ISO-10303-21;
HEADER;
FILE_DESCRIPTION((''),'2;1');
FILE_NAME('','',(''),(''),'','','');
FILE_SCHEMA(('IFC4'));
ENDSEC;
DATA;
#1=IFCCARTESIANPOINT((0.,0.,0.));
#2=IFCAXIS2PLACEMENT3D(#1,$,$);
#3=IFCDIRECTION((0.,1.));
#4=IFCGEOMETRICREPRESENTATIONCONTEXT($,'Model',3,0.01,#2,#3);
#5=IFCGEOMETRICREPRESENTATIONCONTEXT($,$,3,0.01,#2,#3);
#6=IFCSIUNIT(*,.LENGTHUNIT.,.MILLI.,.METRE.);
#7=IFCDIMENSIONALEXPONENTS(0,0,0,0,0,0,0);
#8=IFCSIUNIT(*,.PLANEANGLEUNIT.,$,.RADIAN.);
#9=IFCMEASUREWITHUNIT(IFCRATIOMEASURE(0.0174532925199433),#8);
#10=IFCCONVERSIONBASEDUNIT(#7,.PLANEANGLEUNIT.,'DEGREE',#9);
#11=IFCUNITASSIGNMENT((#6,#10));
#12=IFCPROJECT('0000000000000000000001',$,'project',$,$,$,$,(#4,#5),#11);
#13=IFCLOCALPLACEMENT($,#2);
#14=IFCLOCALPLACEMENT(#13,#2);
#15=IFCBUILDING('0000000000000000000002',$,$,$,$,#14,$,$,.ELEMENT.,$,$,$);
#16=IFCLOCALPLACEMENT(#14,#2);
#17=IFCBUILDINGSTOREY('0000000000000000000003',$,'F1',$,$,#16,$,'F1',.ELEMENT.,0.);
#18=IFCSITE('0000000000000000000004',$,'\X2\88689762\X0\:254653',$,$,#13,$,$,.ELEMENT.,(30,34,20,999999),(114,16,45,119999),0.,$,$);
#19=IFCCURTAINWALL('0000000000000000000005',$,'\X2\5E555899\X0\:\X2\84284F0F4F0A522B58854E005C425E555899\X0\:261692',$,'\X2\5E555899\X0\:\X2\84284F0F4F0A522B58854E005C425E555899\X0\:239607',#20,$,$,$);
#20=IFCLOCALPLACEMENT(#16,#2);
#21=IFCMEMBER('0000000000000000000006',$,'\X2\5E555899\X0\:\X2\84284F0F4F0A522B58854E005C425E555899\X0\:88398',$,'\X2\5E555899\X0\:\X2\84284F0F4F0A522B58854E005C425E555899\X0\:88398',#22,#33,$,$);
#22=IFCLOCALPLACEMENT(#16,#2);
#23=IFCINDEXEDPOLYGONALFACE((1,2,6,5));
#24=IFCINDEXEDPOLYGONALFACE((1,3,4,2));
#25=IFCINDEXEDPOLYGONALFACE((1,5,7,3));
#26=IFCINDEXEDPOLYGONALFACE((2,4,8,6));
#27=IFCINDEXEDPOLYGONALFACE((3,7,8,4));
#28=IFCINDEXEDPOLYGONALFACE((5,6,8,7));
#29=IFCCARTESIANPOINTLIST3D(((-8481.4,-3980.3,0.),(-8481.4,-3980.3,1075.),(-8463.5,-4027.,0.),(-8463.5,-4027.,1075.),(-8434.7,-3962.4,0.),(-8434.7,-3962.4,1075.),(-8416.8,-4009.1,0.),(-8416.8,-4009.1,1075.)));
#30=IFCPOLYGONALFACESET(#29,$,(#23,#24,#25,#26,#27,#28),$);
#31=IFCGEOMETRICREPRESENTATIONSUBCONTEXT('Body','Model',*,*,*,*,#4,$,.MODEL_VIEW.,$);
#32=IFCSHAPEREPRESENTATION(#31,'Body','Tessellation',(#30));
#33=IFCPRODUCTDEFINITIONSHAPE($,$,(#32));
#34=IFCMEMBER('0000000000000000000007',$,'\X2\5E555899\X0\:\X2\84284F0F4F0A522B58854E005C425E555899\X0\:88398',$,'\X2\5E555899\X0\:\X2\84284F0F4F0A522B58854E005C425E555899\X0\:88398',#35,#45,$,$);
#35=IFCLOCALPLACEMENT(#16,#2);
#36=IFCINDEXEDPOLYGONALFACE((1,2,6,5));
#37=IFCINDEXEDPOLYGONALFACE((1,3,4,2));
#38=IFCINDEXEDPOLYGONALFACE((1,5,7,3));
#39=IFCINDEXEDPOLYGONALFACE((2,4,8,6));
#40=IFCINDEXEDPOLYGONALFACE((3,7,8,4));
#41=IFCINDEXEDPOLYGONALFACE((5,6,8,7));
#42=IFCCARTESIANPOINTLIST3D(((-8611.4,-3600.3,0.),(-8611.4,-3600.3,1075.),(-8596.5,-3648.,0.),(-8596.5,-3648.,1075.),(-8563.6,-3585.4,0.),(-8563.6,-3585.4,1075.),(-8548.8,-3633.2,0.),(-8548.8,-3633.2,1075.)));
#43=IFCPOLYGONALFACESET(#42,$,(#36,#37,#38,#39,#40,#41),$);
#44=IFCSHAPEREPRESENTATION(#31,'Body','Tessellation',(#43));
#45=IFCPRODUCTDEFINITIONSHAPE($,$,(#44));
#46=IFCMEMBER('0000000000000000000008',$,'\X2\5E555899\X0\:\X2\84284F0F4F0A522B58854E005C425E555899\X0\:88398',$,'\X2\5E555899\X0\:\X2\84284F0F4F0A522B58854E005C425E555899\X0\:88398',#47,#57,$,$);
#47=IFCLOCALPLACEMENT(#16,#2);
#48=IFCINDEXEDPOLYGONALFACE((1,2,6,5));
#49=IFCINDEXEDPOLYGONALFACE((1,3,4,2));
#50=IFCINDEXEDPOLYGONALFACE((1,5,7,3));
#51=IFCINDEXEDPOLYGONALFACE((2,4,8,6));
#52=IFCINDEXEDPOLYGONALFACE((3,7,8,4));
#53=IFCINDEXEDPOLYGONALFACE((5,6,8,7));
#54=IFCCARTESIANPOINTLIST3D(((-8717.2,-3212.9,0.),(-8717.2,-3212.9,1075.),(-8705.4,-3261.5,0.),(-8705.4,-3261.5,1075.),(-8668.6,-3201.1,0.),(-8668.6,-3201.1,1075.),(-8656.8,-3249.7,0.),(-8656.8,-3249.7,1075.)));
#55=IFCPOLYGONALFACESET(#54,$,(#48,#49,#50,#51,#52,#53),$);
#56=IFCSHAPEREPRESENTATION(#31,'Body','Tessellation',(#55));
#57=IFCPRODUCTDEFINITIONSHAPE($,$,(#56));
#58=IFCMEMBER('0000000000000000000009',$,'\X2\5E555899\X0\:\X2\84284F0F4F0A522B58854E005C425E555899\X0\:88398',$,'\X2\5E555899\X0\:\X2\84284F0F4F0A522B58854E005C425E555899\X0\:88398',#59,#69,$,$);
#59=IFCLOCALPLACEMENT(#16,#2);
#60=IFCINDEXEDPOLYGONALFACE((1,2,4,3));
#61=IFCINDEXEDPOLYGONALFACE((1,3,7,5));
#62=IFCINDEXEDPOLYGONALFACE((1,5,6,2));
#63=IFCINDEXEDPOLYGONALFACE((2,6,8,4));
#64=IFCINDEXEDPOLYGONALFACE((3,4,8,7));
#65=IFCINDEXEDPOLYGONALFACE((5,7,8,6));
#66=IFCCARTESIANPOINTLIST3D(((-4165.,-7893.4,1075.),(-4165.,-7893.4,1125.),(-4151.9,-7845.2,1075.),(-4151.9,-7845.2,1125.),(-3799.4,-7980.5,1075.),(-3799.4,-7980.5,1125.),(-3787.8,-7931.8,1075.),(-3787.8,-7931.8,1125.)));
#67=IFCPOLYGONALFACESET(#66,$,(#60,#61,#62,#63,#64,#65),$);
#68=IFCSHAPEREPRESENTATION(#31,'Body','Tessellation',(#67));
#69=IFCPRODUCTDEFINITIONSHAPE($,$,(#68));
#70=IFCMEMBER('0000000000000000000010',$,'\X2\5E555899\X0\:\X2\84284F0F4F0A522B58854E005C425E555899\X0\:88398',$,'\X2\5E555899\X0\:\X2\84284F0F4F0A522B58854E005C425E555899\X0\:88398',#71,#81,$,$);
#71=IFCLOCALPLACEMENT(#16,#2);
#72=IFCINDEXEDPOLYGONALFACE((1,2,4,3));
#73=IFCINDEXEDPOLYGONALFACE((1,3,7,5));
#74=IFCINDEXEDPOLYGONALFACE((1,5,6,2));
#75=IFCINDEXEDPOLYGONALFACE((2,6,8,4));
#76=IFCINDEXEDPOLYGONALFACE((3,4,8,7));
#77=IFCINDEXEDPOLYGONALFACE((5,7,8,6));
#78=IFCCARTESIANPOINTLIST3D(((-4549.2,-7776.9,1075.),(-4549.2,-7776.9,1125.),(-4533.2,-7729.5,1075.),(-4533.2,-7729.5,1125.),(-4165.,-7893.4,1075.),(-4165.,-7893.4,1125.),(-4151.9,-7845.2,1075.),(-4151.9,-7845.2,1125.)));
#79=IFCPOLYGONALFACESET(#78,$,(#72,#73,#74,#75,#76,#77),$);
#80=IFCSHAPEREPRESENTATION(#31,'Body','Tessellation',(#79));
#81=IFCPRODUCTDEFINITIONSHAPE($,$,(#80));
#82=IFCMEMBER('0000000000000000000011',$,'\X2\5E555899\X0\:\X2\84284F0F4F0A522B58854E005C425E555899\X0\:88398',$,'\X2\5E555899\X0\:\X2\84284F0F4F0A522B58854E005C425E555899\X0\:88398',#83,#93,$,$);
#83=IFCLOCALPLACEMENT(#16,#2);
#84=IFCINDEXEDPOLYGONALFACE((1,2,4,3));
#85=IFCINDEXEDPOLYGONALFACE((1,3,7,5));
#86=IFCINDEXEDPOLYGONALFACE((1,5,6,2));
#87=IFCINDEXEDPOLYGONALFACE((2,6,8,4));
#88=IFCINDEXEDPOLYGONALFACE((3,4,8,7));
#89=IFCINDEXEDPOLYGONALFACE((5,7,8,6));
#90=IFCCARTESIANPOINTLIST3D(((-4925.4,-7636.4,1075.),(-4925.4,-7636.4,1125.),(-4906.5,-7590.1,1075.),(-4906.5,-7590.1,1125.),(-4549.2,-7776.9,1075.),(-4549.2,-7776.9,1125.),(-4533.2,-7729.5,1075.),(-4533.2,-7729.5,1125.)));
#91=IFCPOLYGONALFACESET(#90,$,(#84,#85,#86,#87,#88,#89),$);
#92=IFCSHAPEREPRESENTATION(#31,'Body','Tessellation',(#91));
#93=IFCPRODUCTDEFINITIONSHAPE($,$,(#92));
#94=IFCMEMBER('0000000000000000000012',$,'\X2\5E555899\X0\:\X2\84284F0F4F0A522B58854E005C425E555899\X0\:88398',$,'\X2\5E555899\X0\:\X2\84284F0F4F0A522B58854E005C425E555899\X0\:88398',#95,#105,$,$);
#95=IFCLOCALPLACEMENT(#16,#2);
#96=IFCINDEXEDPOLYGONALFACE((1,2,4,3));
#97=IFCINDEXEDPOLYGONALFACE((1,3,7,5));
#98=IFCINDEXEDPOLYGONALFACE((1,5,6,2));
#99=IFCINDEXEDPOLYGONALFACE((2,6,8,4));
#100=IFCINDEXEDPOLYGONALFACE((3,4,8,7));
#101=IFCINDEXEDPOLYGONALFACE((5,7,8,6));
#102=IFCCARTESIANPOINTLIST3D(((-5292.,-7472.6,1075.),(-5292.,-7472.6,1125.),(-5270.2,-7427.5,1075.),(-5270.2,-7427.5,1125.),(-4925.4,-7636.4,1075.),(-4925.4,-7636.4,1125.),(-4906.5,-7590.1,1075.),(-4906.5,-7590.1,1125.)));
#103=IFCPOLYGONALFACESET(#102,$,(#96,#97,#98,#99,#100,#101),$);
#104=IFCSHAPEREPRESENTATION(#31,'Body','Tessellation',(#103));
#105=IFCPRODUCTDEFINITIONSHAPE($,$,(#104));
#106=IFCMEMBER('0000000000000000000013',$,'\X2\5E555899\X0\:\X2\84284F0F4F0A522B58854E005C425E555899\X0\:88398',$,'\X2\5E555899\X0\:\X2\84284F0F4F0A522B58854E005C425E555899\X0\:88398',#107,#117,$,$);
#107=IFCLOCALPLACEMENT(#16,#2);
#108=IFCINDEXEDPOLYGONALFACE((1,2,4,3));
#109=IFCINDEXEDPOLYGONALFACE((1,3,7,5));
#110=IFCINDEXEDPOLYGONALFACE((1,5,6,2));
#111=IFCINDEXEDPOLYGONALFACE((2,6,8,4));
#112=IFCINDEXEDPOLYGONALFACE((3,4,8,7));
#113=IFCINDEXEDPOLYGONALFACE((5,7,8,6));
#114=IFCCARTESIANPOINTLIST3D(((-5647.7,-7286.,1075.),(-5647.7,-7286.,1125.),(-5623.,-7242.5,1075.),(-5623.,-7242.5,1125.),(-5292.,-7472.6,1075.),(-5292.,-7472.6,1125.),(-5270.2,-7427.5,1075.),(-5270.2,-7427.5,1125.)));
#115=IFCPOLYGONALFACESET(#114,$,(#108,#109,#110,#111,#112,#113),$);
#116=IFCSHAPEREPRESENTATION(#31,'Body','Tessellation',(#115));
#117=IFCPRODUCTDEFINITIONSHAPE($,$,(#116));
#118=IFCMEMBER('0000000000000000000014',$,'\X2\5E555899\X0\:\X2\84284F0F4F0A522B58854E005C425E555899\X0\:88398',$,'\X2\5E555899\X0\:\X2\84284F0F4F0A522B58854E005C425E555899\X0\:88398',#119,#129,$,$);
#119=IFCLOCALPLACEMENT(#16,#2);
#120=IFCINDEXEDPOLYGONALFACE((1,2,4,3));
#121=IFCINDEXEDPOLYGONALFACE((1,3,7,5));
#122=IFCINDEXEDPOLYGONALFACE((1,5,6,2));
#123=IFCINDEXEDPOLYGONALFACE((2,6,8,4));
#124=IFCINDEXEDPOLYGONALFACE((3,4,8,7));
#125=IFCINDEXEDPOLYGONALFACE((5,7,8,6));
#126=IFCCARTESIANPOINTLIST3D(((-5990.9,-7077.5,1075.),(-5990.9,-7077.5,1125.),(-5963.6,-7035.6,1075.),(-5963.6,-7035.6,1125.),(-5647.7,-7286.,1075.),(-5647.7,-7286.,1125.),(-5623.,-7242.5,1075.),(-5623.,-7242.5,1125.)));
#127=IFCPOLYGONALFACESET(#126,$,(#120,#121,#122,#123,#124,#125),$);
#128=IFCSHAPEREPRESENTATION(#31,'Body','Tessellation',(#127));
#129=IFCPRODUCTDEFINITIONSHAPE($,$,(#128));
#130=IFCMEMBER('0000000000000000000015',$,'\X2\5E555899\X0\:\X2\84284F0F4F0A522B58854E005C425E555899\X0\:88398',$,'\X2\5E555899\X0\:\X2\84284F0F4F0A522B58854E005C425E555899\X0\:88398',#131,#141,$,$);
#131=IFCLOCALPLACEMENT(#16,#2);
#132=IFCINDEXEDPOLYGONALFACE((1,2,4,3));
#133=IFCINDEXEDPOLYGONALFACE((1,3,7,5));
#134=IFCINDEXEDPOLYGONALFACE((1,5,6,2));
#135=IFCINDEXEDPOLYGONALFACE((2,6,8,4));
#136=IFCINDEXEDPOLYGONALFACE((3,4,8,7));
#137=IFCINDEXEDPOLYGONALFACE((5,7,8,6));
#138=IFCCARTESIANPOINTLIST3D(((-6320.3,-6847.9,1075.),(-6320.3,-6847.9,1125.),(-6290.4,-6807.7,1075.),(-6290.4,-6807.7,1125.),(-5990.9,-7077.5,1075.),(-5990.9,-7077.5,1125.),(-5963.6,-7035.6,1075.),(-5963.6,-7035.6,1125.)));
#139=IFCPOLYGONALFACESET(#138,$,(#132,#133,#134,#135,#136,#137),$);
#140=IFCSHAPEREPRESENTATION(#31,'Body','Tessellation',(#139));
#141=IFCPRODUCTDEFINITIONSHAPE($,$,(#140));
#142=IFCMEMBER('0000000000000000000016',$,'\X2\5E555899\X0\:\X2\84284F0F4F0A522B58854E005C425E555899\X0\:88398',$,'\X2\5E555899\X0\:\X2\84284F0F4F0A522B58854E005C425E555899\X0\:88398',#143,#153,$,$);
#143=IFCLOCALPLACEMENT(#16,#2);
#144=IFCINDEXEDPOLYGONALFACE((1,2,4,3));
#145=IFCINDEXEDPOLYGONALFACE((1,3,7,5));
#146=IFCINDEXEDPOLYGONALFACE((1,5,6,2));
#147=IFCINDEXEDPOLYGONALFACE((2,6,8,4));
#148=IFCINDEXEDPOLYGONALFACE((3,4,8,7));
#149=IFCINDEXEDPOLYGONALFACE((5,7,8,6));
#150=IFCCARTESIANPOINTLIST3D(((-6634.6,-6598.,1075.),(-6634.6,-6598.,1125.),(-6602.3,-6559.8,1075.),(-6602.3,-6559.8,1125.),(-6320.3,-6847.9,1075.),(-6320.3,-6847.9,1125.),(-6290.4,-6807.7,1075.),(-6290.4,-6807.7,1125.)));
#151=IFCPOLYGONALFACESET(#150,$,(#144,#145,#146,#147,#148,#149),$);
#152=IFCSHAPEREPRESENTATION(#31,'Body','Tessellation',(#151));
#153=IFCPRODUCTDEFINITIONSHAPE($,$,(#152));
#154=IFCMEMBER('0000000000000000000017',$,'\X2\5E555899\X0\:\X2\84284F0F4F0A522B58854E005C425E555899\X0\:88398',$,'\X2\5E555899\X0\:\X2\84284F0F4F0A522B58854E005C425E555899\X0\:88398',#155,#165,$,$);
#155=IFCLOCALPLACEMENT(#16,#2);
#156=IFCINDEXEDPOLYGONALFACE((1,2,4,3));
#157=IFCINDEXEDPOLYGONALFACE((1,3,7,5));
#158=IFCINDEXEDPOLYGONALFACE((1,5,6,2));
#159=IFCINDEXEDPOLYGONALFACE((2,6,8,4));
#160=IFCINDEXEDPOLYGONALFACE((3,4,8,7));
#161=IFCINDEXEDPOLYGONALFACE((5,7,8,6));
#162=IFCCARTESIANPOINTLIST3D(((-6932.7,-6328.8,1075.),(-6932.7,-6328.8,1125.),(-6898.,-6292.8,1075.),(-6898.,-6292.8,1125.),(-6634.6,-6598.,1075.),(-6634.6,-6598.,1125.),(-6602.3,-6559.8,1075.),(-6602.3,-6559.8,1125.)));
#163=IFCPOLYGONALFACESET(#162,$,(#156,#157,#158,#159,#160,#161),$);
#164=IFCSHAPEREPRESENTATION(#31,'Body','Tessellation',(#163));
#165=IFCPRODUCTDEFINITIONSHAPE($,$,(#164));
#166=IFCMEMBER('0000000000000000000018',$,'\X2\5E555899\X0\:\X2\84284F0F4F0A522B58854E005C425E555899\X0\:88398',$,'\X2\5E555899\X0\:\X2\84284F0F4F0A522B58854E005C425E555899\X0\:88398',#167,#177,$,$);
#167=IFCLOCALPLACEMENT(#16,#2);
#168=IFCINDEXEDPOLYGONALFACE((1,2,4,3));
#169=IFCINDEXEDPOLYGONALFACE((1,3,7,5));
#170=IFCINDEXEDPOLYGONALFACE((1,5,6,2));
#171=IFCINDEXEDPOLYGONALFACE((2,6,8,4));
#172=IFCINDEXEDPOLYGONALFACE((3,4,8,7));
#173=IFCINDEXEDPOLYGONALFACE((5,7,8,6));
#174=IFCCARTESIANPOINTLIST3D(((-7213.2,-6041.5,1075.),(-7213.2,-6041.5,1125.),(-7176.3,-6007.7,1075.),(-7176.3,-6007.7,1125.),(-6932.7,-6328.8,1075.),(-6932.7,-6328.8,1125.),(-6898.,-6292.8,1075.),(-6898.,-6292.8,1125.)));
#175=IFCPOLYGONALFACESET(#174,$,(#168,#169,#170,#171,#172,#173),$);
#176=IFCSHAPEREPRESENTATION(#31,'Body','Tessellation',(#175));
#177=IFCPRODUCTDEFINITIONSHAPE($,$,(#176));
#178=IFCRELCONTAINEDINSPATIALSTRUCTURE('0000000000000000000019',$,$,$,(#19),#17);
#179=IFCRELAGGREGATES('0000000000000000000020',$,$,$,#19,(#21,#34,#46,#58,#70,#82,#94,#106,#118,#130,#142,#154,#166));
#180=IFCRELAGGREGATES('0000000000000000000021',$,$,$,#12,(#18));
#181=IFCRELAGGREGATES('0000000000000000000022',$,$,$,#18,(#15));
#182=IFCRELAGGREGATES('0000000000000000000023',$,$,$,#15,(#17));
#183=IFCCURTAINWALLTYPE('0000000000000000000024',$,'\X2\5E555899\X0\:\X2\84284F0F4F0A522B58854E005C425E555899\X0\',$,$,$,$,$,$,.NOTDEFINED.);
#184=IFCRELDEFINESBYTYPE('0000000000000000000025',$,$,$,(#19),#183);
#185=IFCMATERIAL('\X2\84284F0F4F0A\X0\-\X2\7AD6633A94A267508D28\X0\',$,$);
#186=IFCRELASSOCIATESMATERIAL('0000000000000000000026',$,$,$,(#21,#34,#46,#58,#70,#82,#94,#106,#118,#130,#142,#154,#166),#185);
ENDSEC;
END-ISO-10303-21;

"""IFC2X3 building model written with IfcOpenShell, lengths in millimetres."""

from ifc_helpers import new_model, entity, si_unit, converted_unit, direction, frame, frame_2d, origin, origin_2d_with_axis, place, context, subcontext, project, spatial, rectangle, extrude, clip, halfspace, material, type_object, element, aggregate, save


model = new_model("IFC2X3")

# Units and contexts
model_context = context("Model", 3, precision=0.01, world=origin(), true_north=direction((0.0, 1.0)))
context_of_model = context(None, 3, precision=0.01, world=origin(), true_north=direction((0.0, 1.0)))
body_context = subcontext(model_context, "Body", "Model", "MODEL_VIEW")
ifc_project = project(units=[si_unit("LENGTHUNIT", "METRE", prefix="MILLI"), converted_unit("PLANEANGLEUNIT", "DEGREE", entity("IfcRatioMeasure", 0.0174532925199433), si_unit("PLANEANGLEUNIT", "RADIAN"), dimensions=[0, 0, 0, 0, 0, 0, 0])], contexts=[model_context, context_of_model])

# Site, building, storey
site_placement = place(None, origin())
site = spatial("IfcSite", under=ifc_project, at=site_placement, Name="表面:254653", CompositionType="ELEMENT", RefLatitude=(30, 34, 20, 999999), RefLongitude=(114, 16, 45, 119999), RefElevation=0.0)
building_placement = place(site_placement, origin())
building = spatial("IfcBuilding", under=site, at=building_placement, CompositionType="ELEMENT")
storey_placement = place(building_placement, origin())
storey = spatial("IfcBuildingStorey", under=building, at=storey_placement, Name="F1", LongName="F1", CompositionType="ELEMENT", Elevation=0.0)

# Curtain wall, members
curtain_wall_type = type_object("IfcCurtainWallType", Name="幕墙:萨伏伊别墅一层幕墙", PredefinedType="NOTDEFINED")
curtain_wall_placement = place(storey_placement, origin())
curtain_wall = element("IfcCurtainWall", 1, at=curtain_wall_placement, inside=storey, type_object=curtain_wall_type, Name="幕墙:萨伏伊别墅一层幕墙:261692", ObjectType="幕墙:萨伏伊别墅一层幕墙:239607")
ifc_material_1 = material(Name="萨伏伊-竖挺钢材质")
member_1_placement = place(curtain_wall_placement, origin())
member_1 = element("IfcMember", 2, at=member_1_placement, material=ifc_material_1, Name="幕墙:萨伏伊别墅一层幕墙:88398", ObjectType="幕墙:萨伏伊别墅一层幕墙:88398", context=body_context, shape_type="SweptSolid", body=[
    extrude(rectangle(XDim=50.0, YDim=50.0, at=origin_2d_with_axis()), frame((-8449.1, -3994.7, 0.0), z_axis=(0.0, 0.0, 1.0), x_axis=(-0.356897, 0.934144, 0.0)), (0.0, 0.0, 1.0), 1075.0),
])
member_2_placement = place(curtain_wall_placement, origin())
member_2 = element("IfcMember", 3, at=member_2_placement, material=ifc_material_1, Name="幕墙:萨伏伊别墅一层幕墙:88398", ObjectType="幕墙:萨伏伊别墅一层幕墙:88398", context=body_context, shape_type="SweptSolid", body=[
    extrude(rectangle(XDim=50.0, YDim=50.0, at=frame_2d((0.0, 0.0), x_axis=(1.0, 0.0))), frame((-8580.1, -3616.7, 0.0), z_axis=(0.0, 0.0, 1.0), x_axis=(-0.297522, 0.954715, 0.0)), (0.0, 0.0, 1.0), 1075.0),
])
member_3_placement = place(curtain_wall_placement, origin())
member_3 = element("IfcMember", 4, at=member_3_placement, material=ifc_material_1, Name="幕墙:萨伏伊别墅一层幕墙:88398", ObjectType="幕墙:萨伏伊别墅一层幕墙:88398", context=body_context, shape_type="SweptSolid", body=[
    extrude(rectangle(XDim=50.0, YDim=50.0, at=origin_2d_with_axis()), frame((-8687.0, -3231.3, 0.0), z_axis=(0.0, 0.0, 1.0), x_axis=(-0.236972, 0.971517, 0.0)), (0.0, 0.0, 1.0), 1075.0),
])
member_4_placement = place(curtain_wall_placement, origin())
member_4 = element("IfcMember", 5, at=member_4_placement, material=ifc_material_1, Name="幕墙:萨伏伊别墅一层幕墙:88398", ObjectType="幕墙:萨伏伊别墅一层幕墙:88398", context=body_context, shape_type="Clipping", body=[
    clip(extrude(rectangle(XDim=50.0, YDim=50.0, at=frame_2d((0.0, 0.0), x_axis=(1.0, 0.0))), frame((-4159.2, -7869.1, 1100.0), z_axis=(0.972824, -0.231545, 0.0), x_axis=(0.0, 0.0, -1.0)), (0.0, 0.0, 1.0), 375.8), halfspace(frame((-4158.4, -7869.3, 795.2), z_axis=(-0.965326, 0.261048, 0.0), x_axis=(0.261048, 0.965326, 0.0)), False)),
])
member_5_placement = place(curtain_wall_placement, origin())
member_5 = element("IfcMember", 6, at=member_5_placement, material=ifc_material_1, Name="幕墙:萨伏伊别墅一层幕墙:88398", ObjectType="幕墙:萨伏伊别墅一层幕墙:88398", context=body_context, shape_type="Clipping", body=[
    clip(clip(extrude(rectangle(XDim=50.0, YDim=50.0, at=origin_2d_with_axis()), frame((-4542.0, -7753.0, 1100.0), z_axis=(0.956933, -0.290309, 0.0), x_axis=(0.0, 0.0, -1.0)), (0.0, 0.0, 1.0), 401.5), halfspace(frame((-4541.2, -7753.2, 795.2), z_axis=(-0.947339, 0.320231, 0.0), x_axis=(0.320231, 0.947339, 0.0)), False)), halfspace(frame((-4158.4, -7869.3, 795.2), z_axis=(0.965326, -0.261048, 0.0), x_axis=(0.261048, 0.965326, 0.0)), False)),
])
member_6_placement = place(curtain_wall_placement, origin())
member_6 = element("IfcMember", 7, at=member_6_placement, material=ifc_material_1, Name="幕墙:萨伏伊别墅一层幕墙:88398", ObjectType="幕墙:萨伏伊别墅一层幕墙:88398", context=body_context, shape_type="Clipping", body=[
    clip(clip(extrude(rectangle(XDim=50.0, YDim=50.0, at=frame_2d((0.0, 0.0), x_axis=(1.0, 0.0))), frame((-4916.7, -7613.0, 1100.0), z_axis=(0.93681, -0.349838, 0.0), x_axis=(0.0, 0.0, -1.0)), (0.0, 0.0, 1.0), 401.6), halfspace(frame((-4915.9, -7613.2, 795.2), z_axis=(-0.925356, 0.379099, 0.0), x_axis=(0.379099, 0.925356, 0.0)), False)), halfspace(frame((-4541.2, -7753.2, 795.2), z_axis=(0.947339, -0.320231, 0.0), x_axis=(0.320231, 0.947339, 0.0)), False)),
])
member_7_placement = place(curtain_wall_placement, origin())
member_7 = element("IfcMember", 8, at=member_7_placement, material=ifc_material_1, Name="幕墙:萨伏伊别墅一层幕墙:88398", ObjectType="幕墙:萨伏伊别墅一层幕墙:88398", context=body_context, shape_type="Clipping", body=[
    clip(clip(extrude(rectangle(XDim=50.0, YDim=50.0, at=frame_2d((0.0, 0.0), x_axis=(1.0, 0.0))), frame((-5281.9, -7449.7, 1100.0), z_axis=(0.912988, -0.407985, 0.0), x_axis=(0.0, 0.0, -1.0)), (0.0, 0.0, 1.0), 401.6), halfspace(frame((-5281.1, -7450.1, 795.2), z_axis=(-0.899719, 0.436469, 0.0), x_axis=(0.436469, 0.899719, 0.0)), False)), halfspace(frame((-4915.9, -7613.2, 795.2), z_axis=(0.925356, -0.379099, 0.0), x_axis=(0.379099, 0.925356, 0.0)), False)),
])
member_8_placement = place(curtain_wall_placement, origin())
member_8 = element("IfcMember", 9, at=member_8_placement, material=ifc_material_1, Name="幕墙:萨伏伊别墅一层幕墙:88398", ObjectType="幕墙:萨伏伊别墅一层幕墙:88398", context=body_context, shape_type="Clipping", body=[
    clip(clip(extrude(rectangle(XDim=50.0, YDim=50.0, at=frame_2d((0.0, 0.0), x_axis=(1.0, 0.0))), frame((-5636.1, -7263.9, 1100.0), z_axis=(0.885562, -0.464522, 0.0), x_axis=(0.0, 0.0, -1.0)), (0.0, 0.0, 1.0), 401.6), halfspace(frame((-5635.4, -7264.2, 795.2), z_axis=(-0.870529, 0.492116, 0.0), x_axis=(0.492116, 0.870529, 0.0)), False)), halfspace(frame((-5281.1, -7450.1, 795.2), z_axis=(0.899719, -0.436469, 0.0), x_axis=(0.436469, 0.899719, 0.0)), False)),
])
member_9_placement = place(curtain_wall_placement, origin())
member_9 = element("IfcMember", 10, at=member_9_placement, material=ifc_material_1, Name="幕墙:萨伏伊别墅一层幕墙:88398", ObjectType="幕墙:萨伏伊别墅一层幕墙:88398", context=body_context, shape_type="Clipping", body=[
    clip(clip(extrude(rectangle(XDim=50.0, YDim=50.0, at=frame_2d((0.0, 0.0), x_axis=(1.0, 0.0))), frame((-5977.9, -7056.1, 1100.0), z_axis=(0.854638, -0.519225, 0.0), x_axis=(0.0, 0.0, -1.0)), (0.0, 0.0, 1.0), 401.6), halfspace(frame((-5977.2, -7056.6, 795.2), z_axis=(-0.837902, 0.54582, 0.0), x_axis=(0.54582, 0.837902, 0.0)), False)), halfspace(frame((-5635.4, -7264.2, 795.2), z_axis=(0.870529, -0.492116, 0.0), x_axis=(0.492116, 0.870529, 0.0)), False)),
])
member_10_placement = place(curtain_wall_placement, origin())
member_10 = element("IfcMember", 11, at=member_10_placement, material=ifc_material_1, Name="幕墙:萨伏伊别墅一层幕墙:88398", ObjectType="幕墙:萨伏伊别墅一层幕墙:88398", context=body_context, shape_type="Clipping", body=[
    clip(clip(extrude(rectangle(XDim=50.0, YDim=50.0, at=origin_2d_with_axis()), frame((-6306.0, -6827.4, 1100.0), z_axis=(0.82034, -0.571877, 0.0), x_axis=(0.0, 0.0, -1.0)), (0.0, 0.0, 1.0), 401.6), halfspace(frame((-6305.3, -6827.8, 795.2), z_axis=(-0.801967, 0.597369, 0.0), x_axis=(0.597369, 0.801967, 0.0)), False)), halfspace(frame((-5977.2, -7056.6, 795.2), z_axis=(0.837902, -0.54582, 0.0), x_axis=(0.54582, 0.837902, 0.0)), False)),
])
member_11_placement = place(curtain_wall_placement, origin())
member_11 = element("IfcMember", 12, at=member_11_placement, material=ifc_material_1, Name="幕墙:萨伏伊别墅一层幕墙:88398", ObjectType="幕墙:萨伏伊别墅一层幕墙:88398", context=body_context, shape_type="Clipping", body=[
    clip(clip(extrude(rectangle(XDim=50.0, YDim=50.0, at=frame_2d((0.0, 0.0), x_axis=(1.0, 0.0))), frame((-6619.1, -6578.4, 1100.0), z_axis=(0.782802, -0.622271, 0.0), x_axis=(0.0, 0.0, -1.0)), (0.0, 0.0, 1.0), 401.6), halfspace(frame((-6618.5, -6578.9, 795.2), z_axis=(-0.762864, 0.646558, 0.0), x_axis=(0.646558, 0.762864, 0.0)), False)), halfspace(frame((-6305.3, -6827.8, 795.2), z_axis=(0.801967, -0.597369, 0.0), x_axis=(0.597369, 0.801967, 0.0)), False)),
])
member_12_placement = place(curtain_wall_placement, origin())
member_12 = element("IfcMember", 13, at=member_12_placement, material=ifc_material_1, Name="幕墙:萨伏伊别墅一层幕墙:88398", ObjectType="幕墙:萨伏伊别墅一层幕墙:88398", context=body_context, shape_type="Clipping", body=[
    clip(clip(extrude(rectangle(XDim=50.0, YDim=50.0, at=frame_2d((0.0, 0.0), x_axis=(1.0, 0.0))), frame((-6915.9, -6310.3, 1100.0), z_axis=(0.742174, -0.670208, 0.0), x_axis=(0.0, 0.0, -1.0)), (0.0, 0.0, 1.0), 401.6), halfspace(frame((-6915.3, -6310.8, 795.2), z_axis=(-0.72075, 0.693195, 0.0), x_axis=(0.693195, 0.72075, 0.0)), False)), halfspace(frame((-6618.5, -6578.9, 795.2), z_axis=(0.762864, -0.646558, 0.0), x_axis=(0.646558, 0.762864, 0.0)), False)),
])
member_13_placement = place(curtain_wall_placement, origin())
member_13 = element("IfcMember", 14, at=member_13_placement, material=ifc_material_1, Name="幕墙:萨伏伊别墅一层幕墙:88398", ObjectType="幕墙:萨伏伊别墅一层幕墙:88398", context=body_context, shape_type="Clipping", body=[
    clip(clip(extrude(rectangle(XDim=50.0, YDim=50.0, at=origin_2d_with_axis()), frame((-7195.3, -6024.0, 1100.0), z_axis=(0.698614, -0.715498, 0.0), x_axis=(0.0, 0.0, -1.0)), (0.0, 0.0, 1.0), 401.6), halfspace(frame((-7194.8, -6024.6, 795.2), z_axis=(-0.675789, 0.737095, 0.0), x_axis=(0.737095, 0.675789, 0.0)), False)), halfspace(frame((-6915.3, -6310.8, 795.2), z_axis=(0.72075, -0.693195, 0.0), x_axis=(0.693195, 0.72075, 0.0)), False)),
])
aggregate(curtain_wall, [member_1, member_2, member_3, member_4, member_5, member_6, member_7, member_8, member_9, member_10, member_11, member_12, member_13])

save(model, "model.ifc")
